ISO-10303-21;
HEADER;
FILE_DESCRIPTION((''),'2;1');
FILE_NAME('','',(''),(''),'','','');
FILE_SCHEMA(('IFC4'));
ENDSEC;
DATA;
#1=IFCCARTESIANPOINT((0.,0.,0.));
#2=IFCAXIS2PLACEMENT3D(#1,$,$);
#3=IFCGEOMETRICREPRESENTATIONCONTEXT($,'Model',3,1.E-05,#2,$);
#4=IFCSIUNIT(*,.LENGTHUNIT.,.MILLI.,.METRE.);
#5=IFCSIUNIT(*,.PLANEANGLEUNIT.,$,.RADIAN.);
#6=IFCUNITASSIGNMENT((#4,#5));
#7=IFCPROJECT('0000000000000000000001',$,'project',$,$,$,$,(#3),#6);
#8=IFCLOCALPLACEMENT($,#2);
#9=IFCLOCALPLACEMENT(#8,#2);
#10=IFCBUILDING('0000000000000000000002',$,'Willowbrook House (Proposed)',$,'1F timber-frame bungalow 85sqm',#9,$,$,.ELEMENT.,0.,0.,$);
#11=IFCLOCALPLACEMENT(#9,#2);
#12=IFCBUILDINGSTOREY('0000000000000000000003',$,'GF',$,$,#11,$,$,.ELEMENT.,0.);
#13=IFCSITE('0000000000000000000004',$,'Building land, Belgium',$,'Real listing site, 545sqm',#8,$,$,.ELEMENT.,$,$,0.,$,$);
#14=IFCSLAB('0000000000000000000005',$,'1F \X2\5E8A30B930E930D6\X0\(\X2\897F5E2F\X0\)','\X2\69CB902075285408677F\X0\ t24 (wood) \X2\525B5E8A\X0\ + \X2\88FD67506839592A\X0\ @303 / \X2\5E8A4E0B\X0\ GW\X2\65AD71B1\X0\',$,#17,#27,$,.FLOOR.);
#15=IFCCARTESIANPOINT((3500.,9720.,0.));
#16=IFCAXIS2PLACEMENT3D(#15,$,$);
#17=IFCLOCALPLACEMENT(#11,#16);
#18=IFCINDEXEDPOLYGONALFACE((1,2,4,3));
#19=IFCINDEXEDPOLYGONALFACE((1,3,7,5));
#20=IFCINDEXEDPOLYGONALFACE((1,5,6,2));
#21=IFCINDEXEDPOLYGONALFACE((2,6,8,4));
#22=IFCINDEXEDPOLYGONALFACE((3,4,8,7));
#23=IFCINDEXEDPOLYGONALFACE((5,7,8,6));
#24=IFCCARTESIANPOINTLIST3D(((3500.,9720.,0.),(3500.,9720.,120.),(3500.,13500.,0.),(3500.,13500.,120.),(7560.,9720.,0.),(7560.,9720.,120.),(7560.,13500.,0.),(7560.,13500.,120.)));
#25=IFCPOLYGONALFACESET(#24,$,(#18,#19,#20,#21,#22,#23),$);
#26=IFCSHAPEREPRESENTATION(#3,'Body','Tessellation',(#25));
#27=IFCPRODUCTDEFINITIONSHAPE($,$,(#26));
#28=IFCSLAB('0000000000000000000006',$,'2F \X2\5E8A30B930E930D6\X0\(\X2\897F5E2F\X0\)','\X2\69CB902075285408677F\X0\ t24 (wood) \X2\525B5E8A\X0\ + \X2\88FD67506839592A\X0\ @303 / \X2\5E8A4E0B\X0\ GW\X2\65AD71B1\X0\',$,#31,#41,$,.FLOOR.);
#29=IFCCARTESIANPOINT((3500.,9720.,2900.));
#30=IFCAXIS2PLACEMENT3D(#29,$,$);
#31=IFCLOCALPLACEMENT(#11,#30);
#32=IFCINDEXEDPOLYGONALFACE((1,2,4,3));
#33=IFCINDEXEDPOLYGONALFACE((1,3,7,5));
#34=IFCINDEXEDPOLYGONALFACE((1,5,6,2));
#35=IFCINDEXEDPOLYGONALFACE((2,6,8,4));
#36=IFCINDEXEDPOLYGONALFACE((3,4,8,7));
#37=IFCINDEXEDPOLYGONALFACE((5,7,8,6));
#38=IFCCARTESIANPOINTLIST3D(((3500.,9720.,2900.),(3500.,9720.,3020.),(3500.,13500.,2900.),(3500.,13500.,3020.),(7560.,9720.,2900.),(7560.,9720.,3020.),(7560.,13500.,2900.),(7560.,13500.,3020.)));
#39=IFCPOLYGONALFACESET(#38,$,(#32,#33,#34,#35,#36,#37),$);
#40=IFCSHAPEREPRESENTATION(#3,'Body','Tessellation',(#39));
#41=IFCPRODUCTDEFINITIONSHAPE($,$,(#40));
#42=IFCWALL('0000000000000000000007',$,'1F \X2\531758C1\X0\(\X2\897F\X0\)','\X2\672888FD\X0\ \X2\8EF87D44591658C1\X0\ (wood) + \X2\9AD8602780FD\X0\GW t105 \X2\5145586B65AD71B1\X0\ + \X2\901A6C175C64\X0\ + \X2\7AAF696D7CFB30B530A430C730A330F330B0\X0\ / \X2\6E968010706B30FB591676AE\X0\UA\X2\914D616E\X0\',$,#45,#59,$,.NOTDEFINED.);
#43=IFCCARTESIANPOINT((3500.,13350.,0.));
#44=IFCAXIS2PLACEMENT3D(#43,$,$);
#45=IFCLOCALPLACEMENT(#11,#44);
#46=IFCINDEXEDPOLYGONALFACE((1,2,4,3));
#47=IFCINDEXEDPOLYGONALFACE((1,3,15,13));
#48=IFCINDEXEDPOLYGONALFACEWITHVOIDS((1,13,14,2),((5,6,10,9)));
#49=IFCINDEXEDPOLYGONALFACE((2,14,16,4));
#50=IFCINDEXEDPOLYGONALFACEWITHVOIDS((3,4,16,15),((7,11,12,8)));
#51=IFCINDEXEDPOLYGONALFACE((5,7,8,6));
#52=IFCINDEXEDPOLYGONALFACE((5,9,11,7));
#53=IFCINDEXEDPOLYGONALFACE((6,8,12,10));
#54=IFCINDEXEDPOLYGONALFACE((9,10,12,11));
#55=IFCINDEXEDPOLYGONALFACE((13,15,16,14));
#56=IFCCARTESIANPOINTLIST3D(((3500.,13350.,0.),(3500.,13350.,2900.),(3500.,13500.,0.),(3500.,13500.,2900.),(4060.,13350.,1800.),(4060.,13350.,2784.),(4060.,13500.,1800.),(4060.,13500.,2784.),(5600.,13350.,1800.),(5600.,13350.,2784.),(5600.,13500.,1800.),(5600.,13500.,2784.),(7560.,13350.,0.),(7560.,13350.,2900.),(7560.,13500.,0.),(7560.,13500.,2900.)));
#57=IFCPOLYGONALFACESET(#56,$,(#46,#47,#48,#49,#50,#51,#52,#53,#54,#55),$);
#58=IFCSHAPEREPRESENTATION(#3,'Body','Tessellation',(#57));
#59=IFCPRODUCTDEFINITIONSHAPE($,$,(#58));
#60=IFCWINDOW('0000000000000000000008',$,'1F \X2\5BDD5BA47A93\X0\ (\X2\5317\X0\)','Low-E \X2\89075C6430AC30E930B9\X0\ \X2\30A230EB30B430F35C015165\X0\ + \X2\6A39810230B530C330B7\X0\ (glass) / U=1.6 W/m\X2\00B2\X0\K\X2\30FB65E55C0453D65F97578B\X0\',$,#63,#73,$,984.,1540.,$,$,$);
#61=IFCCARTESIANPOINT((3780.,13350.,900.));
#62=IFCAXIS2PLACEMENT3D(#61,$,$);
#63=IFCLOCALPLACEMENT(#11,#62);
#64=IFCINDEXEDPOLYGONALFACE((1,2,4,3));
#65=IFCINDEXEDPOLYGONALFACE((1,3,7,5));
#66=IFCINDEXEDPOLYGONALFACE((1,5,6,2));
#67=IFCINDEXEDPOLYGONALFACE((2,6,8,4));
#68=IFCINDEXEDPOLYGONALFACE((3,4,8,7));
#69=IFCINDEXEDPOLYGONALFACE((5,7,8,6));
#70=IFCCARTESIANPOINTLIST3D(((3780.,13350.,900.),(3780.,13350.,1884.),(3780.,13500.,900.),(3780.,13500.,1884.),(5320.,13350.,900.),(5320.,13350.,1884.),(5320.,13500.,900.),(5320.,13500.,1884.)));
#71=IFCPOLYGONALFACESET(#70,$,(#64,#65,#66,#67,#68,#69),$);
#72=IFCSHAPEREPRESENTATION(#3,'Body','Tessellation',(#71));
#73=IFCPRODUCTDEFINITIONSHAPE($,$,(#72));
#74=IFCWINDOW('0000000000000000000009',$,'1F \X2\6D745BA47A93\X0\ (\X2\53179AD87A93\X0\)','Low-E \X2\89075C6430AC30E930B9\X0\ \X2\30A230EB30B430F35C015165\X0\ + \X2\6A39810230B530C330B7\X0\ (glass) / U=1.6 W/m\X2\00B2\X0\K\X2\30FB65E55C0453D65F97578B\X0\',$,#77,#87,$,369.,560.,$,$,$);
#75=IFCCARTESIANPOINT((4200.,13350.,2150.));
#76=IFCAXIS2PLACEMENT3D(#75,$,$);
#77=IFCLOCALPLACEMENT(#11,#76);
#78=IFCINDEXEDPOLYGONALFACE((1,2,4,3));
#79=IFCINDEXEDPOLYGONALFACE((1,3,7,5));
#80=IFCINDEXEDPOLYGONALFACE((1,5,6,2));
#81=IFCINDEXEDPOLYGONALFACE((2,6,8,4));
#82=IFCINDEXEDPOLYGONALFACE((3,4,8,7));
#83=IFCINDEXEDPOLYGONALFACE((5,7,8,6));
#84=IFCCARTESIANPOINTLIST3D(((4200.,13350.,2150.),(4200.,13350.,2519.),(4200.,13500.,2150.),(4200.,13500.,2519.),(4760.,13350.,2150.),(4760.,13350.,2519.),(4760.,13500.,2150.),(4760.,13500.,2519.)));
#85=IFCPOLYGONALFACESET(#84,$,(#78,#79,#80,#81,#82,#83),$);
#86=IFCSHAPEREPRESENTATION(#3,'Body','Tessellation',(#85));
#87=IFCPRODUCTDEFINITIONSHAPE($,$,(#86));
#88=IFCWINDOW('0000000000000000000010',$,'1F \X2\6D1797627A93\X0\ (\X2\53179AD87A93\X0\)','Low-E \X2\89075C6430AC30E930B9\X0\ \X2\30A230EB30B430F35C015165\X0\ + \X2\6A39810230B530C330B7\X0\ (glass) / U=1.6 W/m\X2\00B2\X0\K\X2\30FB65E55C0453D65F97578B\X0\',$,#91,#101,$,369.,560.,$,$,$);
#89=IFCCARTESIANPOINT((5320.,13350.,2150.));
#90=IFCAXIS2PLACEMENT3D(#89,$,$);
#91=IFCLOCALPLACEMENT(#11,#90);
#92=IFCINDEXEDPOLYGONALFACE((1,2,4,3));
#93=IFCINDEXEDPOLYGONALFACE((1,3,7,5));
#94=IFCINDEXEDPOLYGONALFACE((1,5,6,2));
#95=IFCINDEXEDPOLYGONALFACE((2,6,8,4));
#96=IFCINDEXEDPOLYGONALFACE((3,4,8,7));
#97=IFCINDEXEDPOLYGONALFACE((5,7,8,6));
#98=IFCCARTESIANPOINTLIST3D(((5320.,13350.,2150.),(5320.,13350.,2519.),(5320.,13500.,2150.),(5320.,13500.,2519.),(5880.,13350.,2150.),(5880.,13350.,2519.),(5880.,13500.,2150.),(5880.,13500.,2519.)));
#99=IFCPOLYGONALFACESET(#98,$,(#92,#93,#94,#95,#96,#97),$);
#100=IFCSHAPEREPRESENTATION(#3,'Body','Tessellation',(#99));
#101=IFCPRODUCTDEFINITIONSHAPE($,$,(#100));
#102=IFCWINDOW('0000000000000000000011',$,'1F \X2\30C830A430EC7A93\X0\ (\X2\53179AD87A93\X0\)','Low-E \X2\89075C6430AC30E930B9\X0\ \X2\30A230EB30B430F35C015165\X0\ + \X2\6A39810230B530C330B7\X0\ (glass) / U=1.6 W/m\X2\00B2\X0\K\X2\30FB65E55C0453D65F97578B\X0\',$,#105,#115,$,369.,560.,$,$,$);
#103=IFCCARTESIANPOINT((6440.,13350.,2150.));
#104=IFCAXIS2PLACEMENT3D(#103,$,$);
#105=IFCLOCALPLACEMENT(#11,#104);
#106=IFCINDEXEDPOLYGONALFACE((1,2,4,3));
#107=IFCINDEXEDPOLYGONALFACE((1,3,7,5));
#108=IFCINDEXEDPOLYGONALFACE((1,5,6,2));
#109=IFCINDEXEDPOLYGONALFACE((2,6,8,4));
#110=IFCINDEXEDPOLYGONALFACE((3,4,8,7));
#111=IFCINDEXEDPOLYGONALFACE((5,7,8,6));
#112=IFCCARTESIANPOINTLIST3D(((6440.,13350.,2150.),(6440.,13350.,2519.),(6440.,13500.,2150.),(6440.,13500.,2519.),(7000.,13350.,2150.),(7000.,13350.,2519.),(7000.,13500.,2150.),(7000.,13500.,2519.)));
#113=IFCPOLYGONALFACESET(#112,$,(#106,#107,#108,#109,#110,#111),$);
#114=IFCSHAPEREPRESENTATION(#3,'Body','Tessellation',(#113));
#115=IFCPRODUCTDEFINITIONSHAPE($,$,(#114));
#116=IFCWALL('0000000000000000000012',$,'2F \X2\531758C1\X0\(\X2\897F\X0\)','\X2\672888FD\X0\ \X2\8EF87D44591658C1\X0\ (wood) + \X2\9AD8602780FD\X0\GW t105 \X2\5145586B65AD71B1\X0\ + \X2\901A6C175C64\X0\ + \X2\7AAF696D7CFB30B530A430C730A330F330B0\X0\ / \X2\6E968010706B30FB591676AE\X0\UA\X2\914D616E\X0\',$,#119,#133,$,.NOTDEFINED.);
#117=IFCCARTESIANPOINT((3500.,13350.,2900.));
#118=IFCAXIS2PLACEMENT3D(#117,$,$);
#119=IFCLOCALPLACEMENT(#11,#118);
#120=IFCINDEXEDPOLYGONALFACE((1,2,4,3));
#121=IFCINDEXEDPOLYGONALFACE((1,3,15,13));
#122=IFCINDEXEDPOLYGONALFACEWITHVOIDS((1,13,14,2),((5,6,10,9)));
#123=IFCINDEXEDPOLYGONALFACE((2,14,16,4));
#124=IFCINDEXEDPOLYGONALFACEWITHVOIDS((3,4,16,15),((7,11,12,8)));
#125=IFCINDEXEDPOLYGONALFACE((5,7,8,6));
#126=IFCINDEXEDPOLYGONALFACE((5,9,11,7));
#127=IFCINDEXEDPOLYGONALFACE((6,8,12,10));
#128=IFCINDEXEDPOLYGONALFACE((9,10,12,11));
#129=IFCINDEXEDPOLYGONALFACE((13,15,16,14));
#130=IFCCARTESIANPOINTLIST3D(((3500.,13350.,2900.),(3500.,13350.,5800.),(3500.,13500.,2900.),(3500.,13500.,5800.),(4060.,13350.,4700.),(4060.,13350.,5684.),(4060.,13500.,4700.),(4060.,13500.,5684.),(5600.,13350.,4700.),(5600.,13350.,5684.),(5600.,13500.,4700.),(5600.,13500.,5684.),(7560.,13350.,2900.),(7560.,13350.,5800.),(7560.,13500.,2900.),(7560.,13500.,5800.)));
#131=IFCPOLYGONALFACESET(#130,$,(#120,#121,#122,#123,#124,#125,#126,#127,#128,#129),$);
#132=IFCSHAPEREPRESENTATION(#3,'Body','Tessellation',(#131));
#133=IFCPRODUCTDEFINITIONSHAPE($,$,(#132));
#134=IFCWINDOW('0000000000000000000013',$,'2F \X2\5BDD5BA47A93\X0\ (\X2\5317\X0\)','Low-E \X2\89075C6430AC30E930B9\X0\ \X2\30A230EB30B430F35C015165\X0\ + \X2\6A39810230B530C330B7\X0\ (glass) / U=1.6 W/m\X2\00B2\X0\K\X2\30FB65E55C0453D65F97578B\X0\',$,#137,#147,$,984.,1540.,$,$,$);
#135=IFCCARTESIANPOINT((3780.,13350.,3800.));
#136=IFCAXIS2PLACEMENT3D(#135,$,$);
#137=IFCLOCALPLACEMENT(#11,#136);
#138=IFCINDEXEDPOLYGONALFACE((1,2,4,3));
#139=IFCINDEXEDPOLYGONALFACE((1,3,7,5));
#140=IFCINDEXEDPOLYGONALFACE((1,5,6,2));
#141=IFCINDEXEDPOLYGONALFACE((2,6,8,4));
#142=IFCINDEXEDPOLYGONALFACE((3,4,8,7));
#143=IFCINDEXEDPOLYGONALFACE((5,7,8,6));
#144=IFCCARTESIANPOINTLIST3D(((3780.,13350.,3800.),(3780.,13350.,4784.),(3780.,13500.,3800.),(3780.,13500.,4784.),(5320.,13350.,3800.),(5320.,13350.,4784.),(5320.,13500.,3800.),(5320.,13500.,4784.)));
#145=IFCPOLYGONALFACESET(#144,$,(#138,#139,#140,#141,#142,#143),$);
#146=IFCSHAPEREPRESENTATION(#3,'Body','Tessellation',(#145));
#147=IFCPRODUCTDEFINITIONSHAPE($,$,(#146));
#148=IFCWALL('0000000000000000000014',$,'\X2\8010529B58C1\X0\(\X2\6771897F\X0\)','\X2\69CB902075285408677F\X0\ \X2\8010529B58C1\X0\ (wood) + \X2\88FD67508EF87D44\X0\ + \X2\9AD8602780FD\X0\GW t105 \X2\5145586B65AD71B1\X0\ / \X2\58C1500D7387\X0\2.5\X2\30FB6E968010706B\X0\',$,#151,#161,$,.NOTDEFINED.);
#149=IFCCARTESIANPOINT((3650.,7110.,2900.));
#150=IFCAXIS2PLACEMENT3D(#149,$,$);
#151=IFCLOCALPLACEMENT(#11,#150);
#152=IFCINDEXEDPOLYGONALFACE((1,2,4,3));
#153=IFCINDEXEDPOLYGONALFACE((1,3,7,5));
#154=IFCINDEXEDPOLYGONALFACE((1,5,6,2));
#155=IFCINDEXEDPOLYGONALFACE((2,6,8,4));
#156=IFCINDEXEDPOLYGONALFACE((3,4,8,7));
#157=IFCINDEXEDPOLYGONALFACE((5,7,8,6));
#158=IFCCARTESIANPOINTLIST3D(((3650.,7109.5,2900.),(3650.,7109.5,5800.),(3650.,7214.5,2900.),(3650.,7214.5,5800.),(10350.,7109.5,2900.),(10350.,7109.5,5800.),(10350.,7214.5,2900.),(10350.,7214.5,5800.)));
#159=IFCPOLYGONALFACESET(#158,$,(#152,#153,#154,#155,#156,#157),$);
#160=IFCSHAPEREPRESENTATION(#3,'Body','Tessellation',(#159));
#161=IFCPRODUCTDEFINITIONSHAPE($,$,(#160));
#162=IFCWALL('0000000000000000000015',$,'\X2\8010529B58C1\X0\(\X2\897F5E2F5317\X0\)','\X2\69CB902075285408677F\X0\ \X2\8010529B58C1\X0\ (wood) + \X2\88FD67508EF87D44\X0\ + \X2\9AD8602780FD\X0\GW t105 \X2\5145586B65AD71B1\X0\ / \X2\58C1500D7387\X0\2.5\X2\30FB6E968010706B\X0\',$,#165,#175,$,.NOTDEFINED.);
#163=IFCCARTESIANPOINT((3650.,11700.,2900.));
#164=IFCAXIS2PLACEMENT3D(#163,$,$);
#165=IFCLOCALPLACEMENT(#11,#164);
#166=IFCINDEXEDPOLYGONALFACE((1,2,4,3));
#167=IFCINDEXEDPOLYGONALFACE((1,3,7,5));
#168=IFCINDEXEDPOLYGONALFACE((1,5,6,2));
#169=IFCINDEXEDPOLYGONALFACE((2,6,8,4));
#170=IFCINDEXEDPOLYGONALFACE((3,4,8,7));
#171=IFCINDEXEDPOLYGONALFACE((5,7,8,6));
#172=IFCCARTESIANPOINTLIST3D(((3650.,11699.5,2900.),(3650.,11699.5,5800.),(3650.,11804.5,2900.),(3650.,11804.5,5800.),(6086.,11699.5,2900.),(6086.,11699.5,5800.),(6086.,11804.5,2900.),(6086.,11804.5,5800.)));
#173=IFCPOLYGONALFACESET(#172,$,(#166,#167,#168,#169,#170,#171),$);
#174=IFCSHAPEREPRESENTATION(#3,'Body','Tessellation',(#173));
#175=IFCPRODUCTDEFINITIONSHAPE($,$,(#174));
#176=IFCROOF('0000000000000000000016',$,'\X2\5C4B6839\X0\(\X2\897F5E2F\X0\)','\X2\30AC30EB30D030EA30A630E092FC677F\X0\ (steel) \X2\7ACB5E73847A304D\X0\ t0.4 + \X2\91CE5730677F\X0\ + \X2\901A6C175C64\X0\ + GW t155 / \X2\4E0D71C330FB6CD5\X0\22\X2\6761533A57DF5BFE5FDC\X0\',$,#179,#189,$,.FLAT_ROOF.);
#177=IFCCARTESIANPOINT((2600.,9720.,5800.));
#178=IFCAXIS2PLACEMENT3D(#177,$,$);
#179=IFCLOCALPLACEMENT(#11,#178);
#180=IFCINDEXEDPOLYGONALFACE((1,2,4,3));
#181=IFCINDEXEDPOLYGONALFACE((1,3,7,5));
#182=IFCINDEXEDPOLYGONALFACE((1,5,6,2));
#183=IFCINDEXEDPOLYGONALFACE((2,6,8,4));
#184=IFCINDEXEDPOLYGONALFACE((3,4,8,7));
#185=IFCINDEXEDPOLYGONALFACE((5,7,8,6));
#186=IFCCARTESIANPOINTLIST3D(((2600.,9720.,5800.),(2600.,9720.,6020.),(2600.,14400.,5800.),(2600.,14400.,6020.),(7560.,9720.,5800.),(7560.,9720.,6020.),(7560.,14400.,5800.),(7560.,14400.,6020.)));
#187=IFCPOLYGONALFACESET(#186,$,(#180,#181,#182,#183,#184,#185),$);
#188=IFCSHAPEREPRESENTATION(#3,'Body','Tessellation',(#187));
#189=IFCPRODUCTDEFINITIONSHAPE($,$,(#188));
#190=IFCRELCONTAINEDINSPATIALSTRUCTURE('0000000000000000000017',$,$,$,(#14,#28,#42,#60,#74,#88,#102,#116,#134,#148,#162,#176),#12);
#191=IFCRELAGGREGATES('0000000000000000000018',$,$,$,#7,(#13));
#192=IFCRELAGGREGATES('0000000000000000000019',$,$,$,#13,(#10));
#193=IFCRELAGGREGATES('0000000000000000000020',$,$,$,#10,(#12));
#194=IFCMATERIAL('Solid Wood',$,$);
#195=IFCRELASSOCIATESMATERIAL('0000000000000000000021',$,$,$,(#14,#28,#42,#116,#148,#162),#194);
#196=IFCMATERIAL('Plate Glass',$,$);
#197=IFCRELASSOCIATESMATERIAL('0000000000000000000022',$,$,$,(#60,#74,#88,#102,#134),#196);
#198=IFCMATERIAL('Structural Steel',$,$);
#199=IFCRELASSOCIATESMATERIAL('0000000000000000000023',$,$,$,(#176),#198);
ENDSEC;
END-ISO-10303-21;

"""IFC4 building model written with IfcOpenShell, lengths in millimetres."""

from ifc_helpers import new_model, si_unit, frame, frame_2d, origin, place, context, project, spatial, rectangle, extrude, material, element, fill, save


model = new_model("IFC4")

# Units and contexts
model_context = context("Model", 3, precision=1e-05, world=origin())
ifc_project = project(units=[si_unit("LENGTHUNIT", "METRE", prefix="MILLI"), si_unit("PLANEANGLEUNIT", "RADIAN")], contexts=[model_context])

# Site, building, storey
site_placement = place(None, origin())
site = spatial("IfcSite", under=ifc_project, at=site_placement, Name="Building land, Belgium", ObjectType="Real listing site, 545sqm", CompositionType="ELEMENT", RefElevation=0.0)
building_placement = place(site_placement, origin())
building = spatial("IfcBuilding", under=site, at=building_placement, Name="Willowbrook House (Proposed)", ObjectType="1F timber-frame bungalow 85sqm", CompositionType="ELEMENT", ElevationOfRefHeight=0.0, ElevationOfTerrain=0.0)
storey_placement = place(building_placement, origin())
storey = spatial("IfcBuildingStorey", under=building, at=storey_placement, Name="GF", CompositionType="ELEMENT", Elevation=0.0)

# Slabs
ifc_material_1 = material(Name="Solid Wood")
slab_1_placement = place(storey_placement, frame((3500.0, 9720.0, 0.0)))
element("IfcSlab", 1, at=slab_1_placement, inside=storey, material=ifc_material_1, Name="1F 床スラブ(西帯)", Description="構造用合板 t24 (wood) 剛床 + 製材根太 @303 / 床下 GW断熱", PredefinedType="FLOOR", context=model_context, shape_type="SweptSolid", body=[
    extrude(rectangle(XDim=4060.0, YDim=3780.0, at=frame_2d((2030.0, 1890.0))), frame((3500.0, 9720.0, 0.0)), (0.0, 0.0, 1.0), 120.0),
])
slab_2_placement = place(storey_placement, frame((3500.0, 9720.0, 2900.0)))
element("IfcSlab", 2, at=slab_2_placement, inside=storey, material=ifc_material_1, Name="2F 床スラブ(西帯)", Description="構造用合板 t24 (wood) 剛床 + 製材根太 @303 / 床下 GW断熱", PredefinedType="FLOOR", context=model_context, shape_type="SweptSolid", body=[
    extrude(rectangle(XDim=4060.0, YDim=3780.0, at=frame_2d((2030.0, 1890.0))), frame((3500.0, 9720.0, 2900.0)), (0.0, 0.0, 1.0), 120.0),
])

# Wall, openings, windows
wall_1_placement = place(storey_placement, frame((3500.0, 13350.0, 0.0)))
wall_1 = element("IfcWall", 3, at=wall_1_placement, inside=storey, material=ifc_material_1, Name="1F 北壁(西)", Description="木製 軸組外壁 (wood) + 高性能GW t105 充填断熱 + 通気層 + 窯業系サイディング / 準耐火・外皮UA配慮", PredefinedType="NOTDEFINED", context=model_context, shape_type="SweptSolid", body=[
    extrude(rectangle(XDim=4060.0, YDim=150.0, at=frame_2d((2030.0, 75.0))), frame((3500.0, 13350.0, 0.0)), (0.0, 0.0, 1.0), 2900.0),
])
opening_1_placement = place(storey_placement, frame((3780.0, 13350.0, 900.0)))
opening_1 = element("IfcOpeningElement", 4, at=opening_1_placement, cuts=wall_1, PredefinedType="NOTDEFINED", context=model_context, shape_type="SweptSolid", body=[
    extrude(rectangle(XDim=1540.0, YDim=150.0, at=frame_2d((770.0, 75.0))), frame((3780.0, 13350.0, 900.0)), (0.0, 0.0, 1.0), 984.0),
])
opening_2_placement = place(storey_placement, frame((4200.0, 13350.0, 2150.0)))
opening_2 = element("IfcOpeningElement", 5, at=opening_2_placement, cuts=wall_1, PredefinedType="NOTDEFINED", context=model_context, shape_type="SweptSolid", body=[
    extrude(rectangle(XDim=560.0, YDim=150.0, at=frame_2d((280.0, 75.0))), frame((4200.0, 13350.0, 2150.0)), (0.0, 0.0, 1.0), 369.0),
])
opening_3_placement = place(storey_placement, frame((5320.0, 13350.0, 2150.0)))
opening_3 = element("IfcOpeningElement", 6, at=opening_3_placement, cuts=wall_1, PredefinedType="NOTDEFINED", context=model_context, shape_type="SweptSolid", body=[
    extrude(rectangle(XDim=560.0, YDim=150.0, at=frame_2d((280.0, 75.0))), frame((5320.0, 13350.0, 2150.0)), (0.0, 0.0, 1.0), 369.0),
])
opening_4_placement = place(storey_placement, frame((6440.0, 13350.0, 2150.0)))
opening_4 = element("IfcOpeningElement", 7, at=opening_4_placement, cuts=wall_1, PredefinedType="NOTDEFINED", context=model_context, shape_type="SweptSolid", body=[
    extrude(rectangle(XDim=560.0, YDim=150.0, at=frame_2d((280.0, 75.0))), frame((6440.0, 13350.0, 2150.0)), (0.0, 0.0, 1.0), 369.0),
])
ifc_material_2 = material(Name="Plate Glass")
window_1_placement = place(storey_placement, frame((3780.0, 13350.0, 900.0)))
window_1 = element("IfcWindow", 8, at=window_1_placement, inside=storey, material=ifc_material_2, Name="1F 寝室窓 (北)", Description="Low-E 複層ガラス アルゴン封入 + 樹脂サッシ (glass) / U=1.6 W/m²K・日射取得型", OverallHeight=984.0, OverallWidth=1540.0, context=model_context, shape_type="SweptSolid", body=[
    extrude(rectangle(XDim=1540.0, YDim=150.0, at=frame_2d((770.0, 75.0))), frame((3780.0, 13350.0, 900.0)), (0.0, 0.0, 1.0), 984.0),
])
fill(opening_1, window_1)
window_2_placement = place(storey_placement, frame((4200.0, 13350.0, 2150.0)))
window_2 = element("IfcWindow", 9, at=window_2_placement, inside=storey, material=ifc_material_2, Name="1F 浴室窓 (北高窓)", Description="Low-E 複層ガラス アルゴン封入 + 樹脂サッシ (glass) / U=1.6 W/m²K・日射取得型", OverallHeight=369.0, OverallWidth=560.0, context=model_context, shape_type="SweptSolid", body=[
    extrude(rectangle(XDim=560.0, YDim=150.0, at=frame_2d((280.0, 75.0))), frame((4200.0, 13350.0, 2150.0)), (0.0, 0.0, 1.0), 369.0),
])
fill(opening_2, window_2)
window_3_placement = place(storey_placement, frame((5320.0, 13350.0, 2150.0)))
window_3 = element("IfcWindow", 10, at=window_3_placement, inside=storey, material=ifc_material_2, Name="1F 洗面窓 (北高窓)", Description="Low-E 複層ガラス アルゴン封入 + 樹脂サッシ (glass) / U=1.6 W/m²K・日射取得型", OverallHeight=369.0, OverallWidth=560.0, context=model_context, shape_type="SweptSolid", body=[
    extrude(rectangle(XDim=560.0, YDim=150.0, at=frame_2d((280.0, 75.0))), frame((5320.0, 13350.0, 2150.0)), (0.0, 0.0, 1.0), 369.0),
])
fill(opening_3, window_3)
window_4_placement = place(storey_placement, frame((6440.0, 13350.0, 2150.0)))
window_4 = element("IfcWindow", 11, at=window_4_placement, inside=storey, material=ifc_material_2, Name="1F トイレ窓 (北高窓)", Description="Low-E 複層ガラス アルゴン封入 + 樹脂サッシ (glass) / U=1.6 W/m²K・日射取得型", OverallHeight=369.0, OverallWidth=560.0, context=model_context, shape_type="SweptSolid", body=[
    extrude(rectangle(XDim=560.0, YDim=150.0, at=frame_2d((280.0, 75.0))), frame((6440.0, 13350.0, 2150.0)), (0.0, 0.0, 1.0), 369.0),
])
fill(opening_4, window_4)

# Wall, opening, window
wall_2_placement = place(storey_placement, frame((3500.0, 13350.0, 2900.0)))
wall_2 = element("IfcWall", 12, at=wall_2_placement, inside=storey, material=ifc_material_1, Name="2F 北壁(西)", Description="木製 軸組外壁 (wood) + 高性能GW t105 充填断熱 + 通気層 + 窯業系サイディング / 準耐火・外皮UA配慮", PredefinedType="NOTDEFINED", context=model_context, shape_type="SweptSolid", body=[
    extrude(rectangle(XDim=4060.0, YDim=150.0, at=frame_2d((2030.0, 75.0))), frame((3500.0, 13350.0, 2900.0)), (0.0, 0.0, 1.0), 2900.0),
])
opening_5_placement = place(storey_placement, frame((3780.0, 13350.0, 3800.0)))
opening_5 = element("IfcOpeningElement", 13, at=opening_5_placement, cuts=wall_2, PredefinedType="NOTDEFINED", context=model_context, shape_type="SweptSolid", body=[
    extrude(rectangle(XDim=1540.0, YDim=150.0, at=frame_2d((770.0, 75.0))), frame((3780.0, 13350.0, 3800.0)), (0.0, 0.0, 1.0), 984.0),
])
window_5_placement = place(storey_placement, frame((3780.0, 13350.0, 3800.0)))
window_5 = element("IfcWindow", 14, at=window_5_placement, inside=storey, material=ifc_material_2, Name="2F 寝室窓 (北)", Description="Low-E 複層ガラス アルゴン封入 + 樹脂サッシ (glass) / U=1.6 W/m²K・日射取得型", OverallHeight=984.0, OverallWidth=1540.0, context=model_context, shape_type="SweptSolid", body=[
    extrude(rectangle(XDim=1540.0, YDim=150.0, at=frame_2d((770.0, 75.0))), frame((3780.0, 13350.0, 3800.0)), (0.0, 0.0, 1.0), 984.0),
])
fill(opening_5, window_5)

# Walls
wall_3_placement = place(storey_placement, frame((3650.0, 7110.0, 2900.0)))
element("IfcWall", 15, at=wall_3_placement, inside=storey, material=ifc_material_1, Name="耐力壁(東西)", Description="構造用合板 耐力壁 (wood) + 製材軸組 + 高性能GW t105 充填断熱 / 壁倍率2.5・準耐火", PredefinedType="NOTDEFINED", context=model_context, shape_type="SweptSolid", body=[
    extrude(rectangle(XDim=6700.0, YDim=105.0, at=frame_2d((3350.0, 52.0))), frame((3650.0, 7110.0, 2900.0)), (0.0, 0.0, 1.0), 2900.0),
])
wall_4_placement = place(storey_placement, frame((3650.0, 11700.0, 2900.0)))
element("IfcWall", 16, at=wall_4_placement, inside=storey, material=ifc_material_1, Name="耐力壁(西帯北)", Description="構造用合板 耐力壁 (wood) + 製材軸組 + 高性能GW t105 充填断熱 / 壁倍率2.5・準耐火", PredefinedType="NOTDEFINED", context=model_context, shape_type="SweptSolid", body=[
    extrude(rectangle(XDim=2436.0, YDim=105.0, at=frame_2d((1218.0, 52.0))), frame((3650.0, 11700.0, 2900.0)), (0.0, 0.0, 1.0), 2900.0),
])

# Roof
ifc_material_3 = material(Name="Structural Steel")
for number, where, name in (
    (17, (2600.0, 9720.0, 5800.0), "屋根(西帯)"),
):
    element("IfcRoof", number, at=place(storey_placement, frame(where)), inside=storey, material=ifc_material_3, Name=name, Description="ガルバリウム鋼板 (steel) 立平葺き t0.4 + 野地板 + 通気層 + GW t155 / 不燃・法22条区域対応", PredefinedType="FLAT_ROOF", context=model_context, shape_type="SweptSolid", body=[
        extrude(rectangle(XDim=4960.0, YDim=4680.0, at=frame_2d((2480.0, 2340.0))), frame((2600.0, 9720.0, 5800.0)), (0.0, 0.0, 1.0), 220.0),
    ])

save(model, "model.ifc")
